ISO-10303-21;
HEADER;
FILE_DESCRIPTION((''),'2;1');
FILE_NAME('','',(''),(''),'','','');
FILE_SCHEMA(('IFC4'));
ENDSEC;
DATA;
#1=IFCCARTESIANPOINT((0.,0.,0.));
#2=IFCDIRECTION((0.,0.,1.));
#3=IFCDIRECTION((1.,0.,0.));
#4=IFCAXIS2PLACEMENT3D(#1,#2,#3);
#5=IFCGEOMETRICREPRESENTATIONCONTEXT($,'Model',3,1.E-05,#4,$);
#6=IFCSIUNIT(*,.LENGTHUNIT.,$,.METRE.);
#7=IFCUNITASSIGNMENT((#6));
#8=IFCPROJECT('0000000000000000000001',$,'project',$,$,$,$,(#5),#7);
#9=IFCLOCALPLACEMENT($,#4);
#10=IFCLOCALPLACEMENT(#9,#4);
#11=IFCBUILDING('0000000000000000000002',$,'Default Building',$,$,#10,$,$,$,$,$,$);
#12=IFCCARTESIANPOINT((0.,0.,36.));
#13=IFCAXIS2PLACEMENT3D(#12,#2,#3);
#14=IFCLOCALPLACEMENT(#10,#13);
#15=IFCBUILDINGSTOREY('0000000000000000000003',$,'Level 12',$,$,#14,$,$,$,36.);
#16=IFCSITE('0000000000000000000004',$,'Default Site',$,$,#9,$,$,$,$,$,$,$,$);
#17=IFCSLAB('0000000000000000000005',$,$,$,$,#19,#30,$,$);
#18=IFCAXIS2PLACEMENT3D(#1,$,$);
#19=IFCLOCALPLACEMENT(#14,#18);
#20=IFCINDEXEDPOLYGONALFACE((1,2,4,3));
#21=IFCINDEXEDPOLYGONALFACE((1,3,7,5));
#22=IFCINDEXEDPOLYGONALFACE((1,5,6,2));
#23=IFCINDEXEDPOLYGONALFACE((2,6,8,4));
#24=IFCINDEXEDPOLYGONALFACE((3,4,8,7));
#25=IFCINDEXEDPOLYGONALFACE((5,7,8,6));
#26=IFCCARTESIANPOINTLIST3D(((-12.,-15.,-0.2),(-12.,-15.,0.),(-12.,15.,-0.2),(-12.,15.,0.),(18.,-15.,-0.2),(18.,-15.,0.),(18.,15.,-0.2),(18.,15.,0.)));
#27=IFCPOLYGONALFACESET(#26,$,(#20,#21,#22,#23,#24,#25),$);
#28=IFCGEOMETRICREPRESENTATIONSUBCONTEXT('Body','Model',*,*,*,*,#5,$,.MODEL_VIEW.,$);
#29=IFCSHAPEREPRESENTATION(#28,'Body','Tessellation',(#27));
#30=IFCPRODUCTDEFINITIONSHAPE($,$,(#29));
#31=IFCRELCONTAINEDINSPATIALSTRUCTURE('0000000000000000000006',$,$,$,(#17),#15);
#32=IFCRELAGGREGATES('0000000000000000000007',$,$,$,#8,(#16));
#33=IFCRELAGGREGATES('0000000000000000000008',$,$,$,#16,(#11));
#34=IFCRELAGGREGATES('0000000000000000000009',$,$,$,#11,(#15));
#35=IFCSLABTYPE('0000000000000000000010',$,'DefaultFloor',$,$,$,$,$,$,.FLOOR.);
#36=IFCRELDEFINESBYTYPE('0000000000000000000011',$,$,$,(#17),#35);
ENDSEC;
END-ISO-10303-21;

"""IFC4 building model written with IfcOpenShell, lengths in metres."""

from ifc_helpers import new_model, si_unit, frame, origin_with_axes, place, context, subcontext, project, spatial, polyline, outline, extrude, type_object, element, save


model = new_model("IFC4")

# Units and contexts
model_context = context("Model", 3, precision=1e-05, world=origin_with_axes())
body_context = subcontext(model_context, "Body", "Model", "MODEL_VIEW")
ifc_project = project(units=[si_unit("LENGTHUNIT", "METRE")], contexts=[model_context])

# Site, building, storey
site_placement = place(None, origin_with_axes())
site = spatial("IfcSite", under=ifc_project, at=site_placement, Name="Default Site")
building_placement = place(site_placement, origin_with_axes())
building = spatial("IfcBuilding", under=site, at=building_placement, Name="Default Building")
storey_placement = place(building_placement, frame((0.0, 0.0, 36.0), z_axis=(0.0, 0.0, 1.0), x_axis=(1.0, 0.0, 0.0)))
storey = spatial("IfcBuildingStorey", under=building, at=storey_placement, Name="Level 12", Elevation=36.0)

# Slab
slab_type = type_object("IfcSlabType", Name="DefaultFloor", PredefinedType="FLOOR")
slab_placement = place(storey_placement, frame((0.0, 0.0, -36.0), z_axis=(0.0, 0.0, 1.0), x_axis=(1.0, 0.0, 0.0)))
element("IfcSlab", 1, at=slab_placement, inside=storey, type_object=slab_type, context=body_context, shape_type="SweptSolid", body=[
    extrude(outline(polyline([(-12.0, 15.0), (18.0, 15.0), (18.0, -15.0), (-12.0, -15.0), (-12.0, 15.0)])), frame((0.0, 0.0, 36.0), z_axis=(0.0, 0.0, 1.0), x_axis=(1.0, 0.0, 0.0)), (0.0, 0.0, -1.0), 0.2),
])

save(model, "model.ifc")
